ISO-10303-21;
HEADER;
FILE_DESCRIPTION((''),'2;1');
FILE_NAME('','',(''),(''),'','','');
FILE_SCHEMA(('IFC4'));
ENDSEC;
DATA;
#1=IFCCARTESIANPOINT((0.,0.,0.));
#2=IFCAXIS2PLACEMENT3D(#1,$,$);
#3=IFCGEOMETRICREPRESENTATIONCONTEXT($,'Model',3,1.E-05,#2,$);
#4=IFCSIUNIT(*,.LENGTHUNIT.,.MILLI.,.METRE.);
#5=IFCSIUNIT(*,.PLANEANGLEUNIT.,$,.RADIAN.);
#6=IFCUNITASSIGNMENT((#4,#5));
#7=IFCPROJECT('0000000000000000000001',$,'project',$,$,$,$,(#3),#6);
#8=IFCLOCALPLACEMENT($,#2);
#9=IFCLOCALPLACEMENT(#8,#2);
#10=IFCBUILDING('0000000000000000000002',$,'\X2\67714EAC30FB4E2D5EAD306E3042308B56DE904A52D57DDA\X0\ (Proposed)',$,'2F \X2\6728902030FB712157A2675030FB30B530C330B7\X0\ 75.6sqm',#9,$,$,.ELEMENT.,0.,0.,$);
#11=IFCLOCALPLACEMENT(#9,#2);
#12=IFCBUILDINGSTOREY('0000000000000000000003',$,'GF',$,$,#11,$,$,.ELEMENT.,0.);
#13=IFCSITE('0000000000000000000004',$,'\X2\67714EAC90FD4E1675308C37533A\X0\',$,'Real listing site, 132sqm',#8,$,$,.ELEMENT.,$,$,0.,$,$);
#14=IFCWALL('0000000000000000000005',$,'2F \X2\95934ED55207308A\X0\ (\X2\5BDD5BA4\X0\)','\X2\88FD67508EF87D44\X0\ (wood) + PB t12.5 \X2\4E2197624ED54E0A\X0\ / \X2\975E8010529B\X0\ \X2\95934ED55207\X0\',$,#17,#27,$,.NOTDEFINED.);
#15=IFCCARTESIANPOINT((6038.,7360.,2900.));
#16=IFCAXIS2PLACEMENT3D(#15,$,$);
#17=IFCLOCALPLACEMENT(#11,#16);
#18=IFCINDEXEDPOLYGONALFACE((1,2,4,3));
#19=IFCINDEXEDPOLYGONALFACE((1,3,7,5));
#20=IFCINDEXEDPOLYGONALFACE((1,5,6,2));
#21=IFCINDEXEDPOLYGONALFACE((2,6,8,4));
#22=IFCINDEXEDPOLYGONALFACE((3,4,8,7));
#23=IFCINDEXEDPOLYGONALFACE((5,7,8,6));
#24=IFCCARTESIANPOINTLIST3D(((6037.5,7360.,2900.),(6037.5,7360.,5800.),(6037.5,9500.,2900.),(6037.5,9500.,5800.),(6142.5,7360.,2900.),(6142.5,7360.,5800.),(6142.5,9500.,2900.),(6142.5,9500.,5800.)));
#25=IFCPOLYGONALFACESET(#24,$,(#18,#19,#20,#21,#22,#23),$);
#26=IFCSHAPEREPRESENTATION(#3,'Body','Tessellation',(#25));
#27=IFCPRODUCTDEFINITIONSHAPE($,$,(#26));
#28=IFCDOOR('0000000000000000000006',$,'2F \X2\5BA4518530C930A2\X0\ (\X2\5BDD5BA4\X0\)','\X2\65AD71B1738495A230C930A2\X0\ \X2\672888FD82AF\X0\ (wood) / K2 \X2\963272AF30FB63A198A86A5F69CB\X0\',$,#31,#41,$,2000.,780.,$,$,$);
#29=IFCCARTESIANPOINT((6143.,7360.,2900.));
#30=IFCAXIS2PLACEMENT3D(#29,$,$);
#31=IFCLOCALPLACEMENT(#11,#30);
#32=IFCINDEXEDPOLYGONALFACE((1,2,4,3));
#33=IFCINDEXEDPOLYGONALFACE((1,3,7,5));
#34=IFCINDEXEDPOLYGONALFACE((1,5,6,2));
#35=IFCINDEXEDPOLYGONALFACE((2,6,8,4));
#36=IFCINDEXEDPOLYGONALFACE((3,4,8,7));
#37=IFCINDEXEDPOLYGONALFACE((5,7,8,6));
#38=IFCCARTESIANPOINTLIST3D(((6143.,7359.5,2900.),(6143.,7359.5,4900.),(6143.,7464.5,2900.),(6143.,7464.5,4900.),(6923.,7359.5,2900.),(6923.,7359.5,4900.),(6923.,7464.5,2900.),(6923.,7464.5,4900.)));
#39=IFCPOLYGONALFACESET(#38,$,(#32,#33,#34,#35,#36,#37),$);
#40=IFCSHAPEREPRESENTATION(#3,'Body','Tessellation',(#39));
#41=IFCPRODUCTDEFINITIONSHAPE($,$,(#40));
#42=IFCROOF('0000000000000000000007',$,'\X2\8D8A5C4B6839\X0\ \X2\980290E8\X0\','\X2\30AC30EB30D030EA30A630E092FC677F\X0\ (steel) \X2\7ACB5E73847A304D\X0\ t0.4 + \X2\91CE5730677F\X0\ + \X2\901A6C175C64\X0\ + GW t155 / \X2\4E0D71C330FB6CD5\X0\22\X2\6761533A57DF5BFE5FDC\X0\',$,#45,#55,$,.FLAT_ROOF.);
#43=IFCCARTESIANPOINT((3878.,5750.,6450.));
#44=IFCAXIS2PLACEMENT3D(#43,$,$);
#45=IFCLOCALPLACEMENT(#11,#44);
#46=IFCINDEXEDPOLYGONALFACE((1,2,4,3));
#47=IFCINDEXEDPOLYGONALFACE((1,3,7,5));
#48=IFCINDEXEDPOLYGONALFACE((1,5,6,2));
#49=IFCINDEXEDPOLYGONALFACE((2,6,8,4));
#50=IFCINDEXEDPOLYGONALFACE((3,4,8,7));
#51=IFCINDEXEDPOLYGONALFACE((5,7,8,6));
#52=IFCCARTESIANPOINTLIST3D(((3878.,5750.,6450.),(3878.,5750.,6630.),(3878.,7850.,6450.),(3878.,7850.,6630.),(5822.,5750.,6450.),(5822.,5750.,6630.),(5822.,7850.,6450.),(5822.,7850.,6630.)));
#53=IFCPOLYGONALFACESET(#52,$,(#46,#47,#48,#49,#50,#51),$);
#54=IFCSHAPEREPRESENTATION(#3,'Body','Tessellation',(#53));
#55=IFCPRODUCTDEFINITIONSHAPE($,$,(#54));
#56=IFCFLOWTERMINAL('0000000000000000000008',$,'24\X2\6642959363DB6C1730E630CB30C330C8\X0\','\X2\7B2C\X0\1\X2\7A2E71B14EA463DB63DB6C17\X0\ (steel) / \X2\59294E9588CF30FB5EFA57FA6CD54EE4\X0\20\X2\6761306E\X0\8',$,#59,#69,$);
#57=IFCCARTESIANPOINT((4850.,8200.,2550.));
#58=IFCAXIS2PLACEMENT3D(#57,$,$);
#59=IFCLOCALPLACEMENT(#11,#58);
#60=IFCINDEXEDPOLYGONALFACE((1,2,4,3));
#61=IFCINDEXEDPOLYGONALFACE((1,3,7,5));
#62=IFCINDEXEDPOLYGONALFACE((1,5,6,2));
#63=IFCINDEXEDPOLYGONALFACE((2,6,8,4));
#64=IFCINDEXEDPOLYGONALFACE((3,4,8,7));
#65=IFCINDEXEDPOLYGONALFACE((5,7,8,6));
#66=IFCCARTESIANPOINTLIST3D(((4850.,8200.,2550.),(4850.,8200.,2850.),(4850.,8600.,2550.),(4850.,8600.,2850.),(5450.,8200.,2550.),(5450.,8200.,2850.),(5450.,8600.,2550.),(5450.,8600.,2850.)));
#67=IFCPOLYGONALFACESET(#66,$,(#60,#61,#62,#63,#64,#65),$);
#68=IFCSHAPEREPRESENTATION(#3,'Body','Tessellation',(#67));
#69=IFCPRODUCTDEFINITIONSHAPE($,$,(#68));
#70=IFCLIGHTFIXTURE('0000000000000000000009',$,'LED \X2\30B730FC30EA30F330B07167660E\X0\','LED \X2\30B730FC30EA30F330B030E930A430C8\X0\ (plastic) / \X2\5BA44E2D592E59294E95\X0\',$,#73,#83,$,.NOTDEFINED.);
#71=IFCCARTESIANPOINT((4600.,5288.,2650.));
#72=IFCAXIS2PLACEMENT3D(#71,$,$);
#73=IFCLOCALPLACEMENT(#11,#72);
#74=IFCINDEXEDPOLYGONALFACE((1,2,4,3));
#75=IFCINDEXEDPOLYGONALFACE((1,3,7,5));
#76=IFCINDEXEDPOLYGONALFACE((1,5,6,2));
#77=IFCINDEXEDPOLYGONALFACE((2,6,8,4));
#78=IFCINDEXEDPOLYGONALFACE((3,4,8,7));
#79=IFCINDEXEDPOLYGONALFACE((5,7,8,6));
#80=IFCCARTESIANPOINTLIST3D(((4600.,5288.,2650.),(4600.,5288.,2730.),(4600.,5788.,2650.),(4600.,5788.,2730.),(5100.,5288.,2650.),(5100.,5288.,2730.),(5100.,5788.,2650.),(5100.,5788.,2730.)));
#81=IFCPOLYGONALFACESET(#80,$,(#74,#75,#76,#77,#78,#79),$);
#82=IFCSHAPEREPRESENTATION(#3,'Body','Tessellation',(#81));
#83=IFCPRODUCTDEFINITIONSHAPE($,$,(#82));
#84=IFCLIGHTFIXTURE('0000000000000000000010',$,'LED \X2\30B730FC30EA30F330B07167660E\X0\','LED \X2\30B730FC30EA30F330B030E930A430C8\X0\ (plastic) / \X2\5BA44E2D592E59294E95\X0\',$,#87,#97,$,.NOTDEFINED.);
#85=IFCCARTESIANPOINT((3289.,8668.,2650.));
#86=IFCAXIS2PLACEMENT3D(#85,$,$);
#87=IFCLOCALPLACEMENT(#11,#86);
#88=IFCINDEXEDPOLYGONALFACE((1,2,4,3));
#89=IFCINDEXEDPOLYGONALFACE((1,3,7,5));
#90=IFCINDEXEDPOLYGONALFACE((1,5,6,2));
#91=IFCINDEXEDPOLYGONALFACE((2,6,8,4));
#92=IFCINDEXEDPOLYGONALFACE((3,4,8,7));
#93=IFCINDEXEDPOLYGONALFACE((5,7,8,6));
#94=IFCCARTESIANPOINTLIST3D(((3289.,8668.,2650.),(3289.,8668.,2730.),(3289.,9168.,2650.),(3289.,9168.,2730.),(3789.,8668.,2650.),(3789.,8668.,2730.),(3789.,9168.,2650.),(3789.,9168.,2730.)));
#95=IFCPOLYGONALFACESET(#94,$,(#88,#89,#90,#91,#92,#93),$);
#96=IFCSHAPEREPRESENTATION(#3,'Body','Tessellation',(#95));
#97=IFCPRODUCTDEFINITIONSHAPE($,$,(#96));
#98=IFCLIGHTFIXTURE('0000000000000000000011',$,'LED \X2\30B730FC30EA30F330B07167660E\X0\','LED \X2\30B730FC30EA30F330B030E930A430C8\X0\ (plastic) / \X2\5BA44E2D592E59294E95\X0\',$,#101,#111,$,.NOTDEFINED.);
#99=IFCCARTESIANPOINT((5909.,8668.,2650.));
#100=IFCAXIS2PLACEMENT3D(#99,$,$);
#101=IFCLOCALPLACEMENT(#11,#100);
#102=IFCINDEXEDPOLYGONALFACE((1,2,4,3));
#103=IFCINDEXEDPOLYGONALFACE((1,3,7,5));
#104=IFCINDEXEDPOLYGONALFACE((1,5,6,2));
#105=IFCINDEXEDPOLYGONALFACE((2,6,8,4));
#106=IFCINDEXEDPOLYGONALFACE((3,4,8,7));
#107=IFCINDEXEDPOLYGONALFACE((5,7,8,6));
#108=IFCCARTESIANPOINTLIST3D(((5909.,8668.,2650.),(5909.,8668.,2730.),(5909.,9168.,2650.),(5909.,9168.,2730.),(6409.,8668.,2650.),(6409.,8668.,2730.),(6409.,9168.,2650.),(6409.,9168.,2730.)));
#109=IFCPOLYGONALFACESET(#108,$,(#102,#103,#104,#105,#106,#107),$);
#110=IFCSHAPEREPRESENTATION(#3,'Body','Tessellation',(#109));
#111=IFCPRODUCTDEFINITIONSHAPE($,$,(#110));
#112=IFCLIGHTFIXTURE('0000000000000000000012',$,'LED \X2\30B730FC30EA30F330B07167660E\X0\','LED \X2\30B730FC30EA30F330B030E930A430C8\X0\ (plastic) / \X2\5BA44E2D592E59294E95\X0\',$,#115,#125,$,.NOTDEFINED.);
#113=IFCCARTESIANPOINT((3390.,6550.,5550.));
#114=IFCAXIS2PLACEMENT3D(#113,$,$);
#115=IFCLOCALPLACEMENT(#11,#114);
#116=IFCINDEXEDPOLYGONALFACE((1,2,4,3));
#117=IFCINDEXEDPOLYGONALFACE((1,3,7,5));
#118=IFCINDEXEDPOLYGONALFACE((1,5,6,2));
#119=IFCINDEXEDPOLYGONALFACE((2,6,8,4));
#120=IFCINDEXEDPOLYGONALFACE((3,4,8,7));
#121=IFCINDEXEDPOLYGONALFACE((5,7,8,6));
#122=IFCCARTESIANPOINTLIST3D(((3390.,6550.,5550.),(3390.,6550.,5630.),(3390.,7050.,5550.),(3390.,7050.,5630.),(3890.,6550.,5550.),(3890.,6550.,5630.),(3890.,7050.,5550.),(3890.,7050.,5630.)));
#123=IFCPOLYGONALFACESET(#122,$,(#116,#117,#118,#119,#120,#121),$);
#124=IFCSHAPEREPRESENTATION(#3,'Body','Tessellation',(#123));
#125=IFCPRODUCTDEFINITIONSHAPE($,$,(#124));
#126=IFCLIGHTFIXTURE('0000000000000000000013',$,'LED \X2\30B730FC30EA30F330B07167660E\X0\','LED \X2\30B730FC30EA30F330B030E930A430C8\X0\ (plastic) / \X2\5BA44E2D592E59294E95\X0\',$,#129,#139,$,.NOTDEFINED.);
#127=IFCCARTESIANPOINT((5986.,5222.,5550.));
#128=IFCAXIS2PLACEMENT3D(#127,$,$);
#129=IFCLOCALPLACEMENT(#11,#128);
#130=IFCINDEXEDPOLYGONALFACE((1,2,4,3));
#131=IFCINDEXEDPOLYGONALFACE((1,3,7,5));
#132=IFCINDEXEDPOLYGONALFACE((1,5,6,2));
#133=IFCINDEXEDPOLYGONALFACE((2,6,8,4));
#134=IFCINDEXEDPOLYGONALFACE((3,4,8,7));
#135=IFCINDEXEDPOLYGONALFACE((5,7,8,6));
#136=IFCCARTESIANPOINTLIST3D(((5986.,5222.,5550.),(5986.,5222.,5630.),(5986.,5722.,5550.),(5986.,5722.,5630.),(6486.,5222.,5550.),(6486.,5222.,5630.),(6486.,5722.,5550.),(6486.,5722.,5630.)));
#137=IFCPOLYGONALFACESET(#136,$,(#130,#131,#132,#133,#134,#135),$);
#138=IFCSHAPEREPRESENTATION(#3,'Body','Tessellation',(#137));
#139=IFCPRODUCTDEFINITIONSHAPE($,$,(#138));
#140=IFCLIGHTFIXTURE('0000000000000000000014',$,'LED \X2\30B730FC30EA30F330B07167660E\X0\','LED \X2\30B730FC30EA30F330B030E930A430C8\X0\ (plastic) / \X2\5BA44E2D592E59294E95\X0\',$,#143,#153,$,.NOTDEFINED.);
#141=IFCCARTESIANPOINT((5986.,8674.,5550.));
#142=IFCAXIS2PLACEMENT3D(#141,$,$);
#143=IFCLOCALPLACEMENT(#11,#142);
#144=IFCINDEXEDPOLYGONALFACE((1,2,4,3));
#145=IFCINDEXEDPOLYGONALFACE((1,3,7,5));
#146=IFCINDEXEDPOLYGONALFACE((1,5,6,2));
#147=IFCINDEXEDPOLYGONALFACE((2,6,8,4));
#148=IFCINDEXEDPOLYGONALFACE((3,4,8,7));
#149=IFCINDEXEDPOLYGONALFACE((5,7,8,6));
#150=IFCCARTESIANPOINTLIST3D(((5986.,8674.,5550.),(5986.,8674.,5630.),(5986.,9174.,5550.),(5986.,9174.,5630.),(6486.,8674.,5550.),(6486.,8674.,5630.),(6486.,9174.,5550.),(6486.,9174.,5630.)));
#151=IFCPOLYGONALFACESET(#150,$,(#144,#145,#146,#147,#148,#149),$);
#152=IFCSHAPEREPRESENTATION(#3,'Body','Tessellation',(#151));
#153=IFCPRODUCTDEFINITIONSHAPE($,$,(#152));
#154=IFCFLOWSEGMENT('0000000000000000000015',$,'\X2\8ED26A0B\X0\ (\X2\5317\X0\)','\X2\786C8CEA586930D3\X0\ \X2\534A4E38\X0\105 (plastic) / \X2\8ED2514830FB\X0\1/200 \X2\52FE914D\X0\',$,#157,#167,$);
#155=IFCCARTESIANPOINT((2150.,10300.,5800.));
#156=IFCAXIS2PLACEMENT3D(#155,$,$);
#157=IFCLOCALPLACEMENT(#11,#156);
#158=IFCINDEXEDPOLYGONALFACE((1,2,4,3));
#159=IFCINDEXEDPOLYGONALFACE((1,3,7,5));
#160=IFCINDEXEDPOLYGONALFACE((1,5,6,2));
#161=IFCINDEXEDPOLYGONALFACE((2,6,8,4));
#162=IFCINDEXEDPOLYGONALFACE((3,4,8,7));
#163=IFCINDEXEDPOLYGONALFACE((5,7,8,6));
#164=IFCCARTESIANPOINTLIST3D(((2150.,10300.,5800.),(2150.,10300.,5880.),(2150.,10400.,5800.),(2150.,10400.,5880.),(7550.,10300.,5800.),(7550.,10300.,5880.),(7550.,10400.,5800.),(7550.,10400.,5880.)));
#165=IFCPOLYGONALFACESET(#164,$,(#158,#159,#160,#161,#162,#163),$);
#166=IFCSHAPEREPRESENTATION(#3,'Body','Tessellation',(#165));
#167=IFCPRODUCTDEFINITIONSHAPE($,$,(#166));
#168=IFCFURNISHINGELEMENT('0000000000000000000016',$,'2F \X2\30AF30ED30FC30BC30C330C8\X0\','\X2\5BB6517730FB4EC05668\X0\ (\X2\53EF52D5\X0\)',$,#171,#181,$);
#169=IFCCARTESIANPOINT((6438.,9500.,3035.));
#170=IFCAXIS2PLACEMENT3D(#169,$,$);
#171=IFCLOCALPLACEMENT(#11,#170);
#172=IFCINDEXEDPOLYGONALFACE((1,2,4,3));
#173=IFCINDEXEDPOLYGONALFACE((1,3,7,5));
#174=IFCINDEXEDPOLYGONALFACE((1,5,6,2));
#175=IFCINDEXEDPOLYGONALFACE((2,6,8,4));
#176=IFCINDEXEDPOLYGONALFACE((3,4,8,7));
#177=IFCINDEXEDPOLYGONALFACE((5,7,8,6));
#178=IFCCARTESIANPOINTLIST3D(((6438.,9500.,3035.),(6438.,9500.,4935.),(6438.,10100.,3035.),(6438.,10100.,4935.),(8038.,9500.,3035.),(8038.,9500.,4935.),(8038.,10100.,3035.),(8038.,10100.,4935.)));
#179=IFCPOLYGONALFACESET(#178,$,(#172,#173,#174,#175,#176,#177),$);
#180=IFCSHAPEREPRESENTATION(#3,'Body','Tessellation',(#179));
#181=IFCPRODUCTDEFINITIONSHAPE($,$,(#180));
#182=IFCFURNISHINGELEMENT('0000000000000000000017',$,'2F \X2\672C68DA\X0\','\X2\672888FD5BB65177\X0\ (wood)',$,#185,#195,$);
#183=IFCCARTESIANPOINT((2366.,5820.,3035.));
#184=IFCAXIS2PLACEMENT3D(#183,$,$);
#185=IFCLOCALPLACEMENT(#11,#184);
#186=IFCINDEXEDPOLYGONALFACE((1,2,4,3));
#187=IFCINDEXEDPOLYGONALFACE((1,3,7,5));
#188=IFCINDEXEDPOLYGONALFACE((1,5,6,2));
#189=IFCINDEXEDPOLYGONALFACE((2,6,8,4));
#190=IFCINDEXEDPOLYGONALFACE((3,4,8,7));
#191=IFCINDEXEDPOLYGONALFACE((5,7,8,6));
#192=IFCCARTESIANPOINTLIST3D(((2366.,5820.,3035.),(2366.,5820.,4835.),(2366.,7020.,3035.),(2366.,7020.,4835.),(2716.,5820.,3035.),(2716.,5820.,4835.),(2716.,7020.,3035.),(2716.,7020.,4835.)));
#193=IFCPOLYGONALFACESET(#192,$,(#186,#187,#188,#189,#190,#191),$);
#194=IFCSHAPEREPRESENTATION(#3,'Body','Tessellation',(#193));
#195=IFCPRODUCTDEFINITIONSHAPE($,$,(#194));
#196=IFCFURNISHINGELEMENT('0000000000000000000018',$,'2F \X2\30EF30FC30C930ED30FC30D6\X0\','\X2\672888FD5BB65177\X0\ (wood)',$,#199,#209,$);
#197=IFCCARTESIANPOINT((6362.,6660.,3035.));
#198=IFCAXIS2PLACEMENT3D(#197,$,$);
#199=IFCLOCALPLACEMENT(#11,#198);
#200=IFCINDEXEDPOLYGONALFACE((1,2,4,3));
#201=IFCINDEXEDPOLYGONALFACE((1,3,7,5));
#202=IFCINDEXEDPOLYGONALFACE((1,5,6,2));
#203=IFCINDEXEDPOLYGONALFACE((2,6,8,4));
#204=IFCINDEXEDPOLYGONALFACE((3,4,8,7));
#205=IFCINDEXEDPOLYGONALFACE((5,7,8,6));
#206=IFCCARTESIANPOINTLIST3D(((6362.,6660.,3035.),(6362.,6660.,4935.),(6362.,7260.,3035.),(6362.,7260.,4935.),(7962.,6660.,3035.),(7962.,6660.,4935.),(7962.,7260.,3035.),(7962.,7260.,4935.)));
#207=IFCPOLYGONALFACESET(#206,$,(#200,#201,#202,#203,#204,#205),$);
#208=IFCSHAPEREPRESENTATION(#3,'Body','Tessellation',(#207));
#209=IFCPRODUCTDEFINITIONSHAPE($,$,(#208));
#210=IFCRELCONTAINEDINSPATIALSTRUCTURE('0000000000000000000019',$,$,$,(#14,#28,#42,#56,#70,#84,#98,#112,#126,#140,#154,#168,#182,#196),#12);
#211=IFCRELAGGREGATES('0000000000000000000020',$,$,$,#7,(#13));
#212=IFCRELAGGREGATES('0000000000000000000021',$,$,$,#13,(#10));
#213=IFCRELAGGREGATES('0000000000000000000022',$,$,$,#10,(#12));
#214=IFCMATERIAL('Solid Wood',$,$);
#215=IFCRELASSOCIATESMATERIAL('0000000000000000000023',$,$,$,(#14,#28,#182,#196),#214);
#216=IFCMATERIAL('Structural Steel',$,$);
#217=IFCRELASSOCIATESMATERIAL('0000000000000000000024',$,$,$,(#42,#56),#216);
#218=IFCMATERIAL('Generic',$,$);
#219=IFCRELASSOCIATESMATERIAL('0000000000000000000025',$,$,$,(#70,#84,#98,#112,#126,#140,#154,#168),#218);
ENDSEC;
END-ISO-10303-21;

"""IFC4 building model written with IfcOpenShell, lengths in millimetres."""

from ifc_helpers import new_model, si_unit, frame, frame_2d, origin, place, context, project, spatial, rectangle, extrude, material, element, save


model = new_model("IFC4")

# Units and contexts
model_context = context("Model", 3, precision=1e-05, world=origin())
ifc_project = project(units=[si_unit("LENGTHUNIT", "METRE", prefix="MILLI"), si_unit("PLANEANGLEUNIT", "RADIAN")], contexts=[model_context])

# Site, building, storey
site_placement = place(None, origin())
site = spatial("IfcSite", under=ifc_project, at=site_placement, Name="東京都世田谷区", ObjectType="Real listing site, 132sqm", CompositionType="ELEMENT", RefElevation=0.0)
building_placement = place(site_placement, origin())
building = spatial("IfcBuilding", under=site, at=building_placement, Name="東京・中庭のある回遊動線 (Proposed)", ObjectType="2F 木造・無垢材・サッシ 75.6sqm", CompositionType="ELEMENT", ElevationOfRefHeight=0.0, ElevationOfTerrain=0.0)
storey_placement = place(building_placement, origin())
storey = spatial("IfcBuildingStorey", under=building, at=storey_placement, Name="GF", CompositionType="ELEMENT", Elevation=0.0)

# Shared definitions
ifc_material_1 = material(Name="Solid Wood")

# Wall
wall_1_placement = place(storey_placement, frame((6038.0, 7360.0, 2900.0)))
element("IfcWall", 1, at=wall_1_placement, inside=storey, material=ifc_material_1, Name="2F 間仕切り (寝室)", Description="製材軸組 (wood) + PB t12.5 両面仕上 / 非耐力 間仕切", PredefinedType="NOTDEFINED", context=model_context, shape_type="SweptSolid", body=[
    extrude(rectangle(XDim=105.0, YDim=2140.0, at=frame_2d((52.0, 1070.0))), frame((6038.0, 7360.0, 2900.0)), (0.0, 0.0, 1.0), 2900.0),
])

# Door
door_placement = place(storey_placement, frame((6143.0, 7360.0, 2900.0)))
element("IfcDoor", 2, at=door_placement, inside=storey, material=ifc_material_1, Name="2F 室内ドア (寝室)", Description="断熱玄関ドア 木製芯 (wood) / K2 防犯・採風機構", OverallHeight=2000.0, OverallWidth=780.0, context=model_context, shape_type="SweptSolid", body=[
    extrude(rectangle(XDim=780.0, YDim=105.0, at=frame_2d((390.0, 52.0))), frame((6143.0, 7360.0, 2900.0)), (0.0, 0.0, 1.0), 2000.0),
])

# Roof
ifc_material_2 = material(Name="Structural Steel")
roof_placement = place(storey_placement, frame((3878.0, 5750.0, 6450.0)))
element("IfcRoof", 3, at=roof_placement, inside=storey, material=ifc_material_2, Name="越屋根 頂部", Description="ガルバリウム鋼板 (steel) 立平葺き t0.4 + 野地板 + 通気層 + GW t155 / 不燃・法22条区域対応", PredefinedType="FLAT_ROOF", context=model_context, shape_type="SweptSolid", body=[
    extrude(rectangle(XDim=1944.0, YDim=2100.0, at=frame_2d((972.0, 1050.0))), frame((3878.0, 5750.0, 6450.0)), (0.0, 0.0, 1.0), 180.0),
])

# Flow terminal
flow_terminal_placement = place(storey_placement, frame((4850.0, 8200.0, 2550.0)))
element("IfcFlowTerminal", 4, at=flow_terminal_placement, inside=storey, material=ifc_material_2, Name="24時間換気ユニット", Description="第1種熱交換換気 (steel) / 天井裏・建基法令20条の8", context=model_context, shape_type="SweptSolid", body=[
    extrude(rectangle(XDim=600.0, YDim=400.0, at=frame_2d((300.0, 200.0))), frame((4850.0, 8200.0, 2550.0)), (0.0, 0.0, 1.0), 300.0),
])

# Light fixtures
ifc_material_3 = material(Name="Generic")
light_fixture_1_placement = place(storey_placement, frame((4600.0, 5288.0, 2650.0)))
element("IfcLightFixture", 5, at=light_fixture_1_placement, inside=storey, material=ifc_material_3, Name="LED シーリング照明", Description="LED シーリングライト (plastic) / 室中央天井", PredefinedType="NOTDEFINED", context=model_context, shape_type="SweptSolid", body=[
    extrude(rectangle(XDim=500.0, YDim=500.0, at=frame_2d((250.0, 250.0))), frame((4600.0, 5288.0, 2650.0)), (0.0, 0.0, 1.0), 80.0),
])
light_fixture_2_placement = place(storey_placement, frame((3289.0, 8668.0, 2650.0)))
element("IfcLightFixture", 6, at=light_fixture_2_placement, inside=storey, material=ifc_material_3, Name="LED シーリング照明", Description="LED シーリングライト (plastic) / 室中央天井", PredefinedType="NOTDEFINED", context=model_context, shape_type="SweptSolid", body=[
    extrude(rectangle(XDim=500.0, YDim=500.0, at=frame_2d((250.0, 250.0))), frame((3289.0, 8668.0, 2650.0)), (0.0, 0.0, 1.0), 80.0),
])
light_fixture_3_placement = place(storey_placement, frame((5909.0, 8668.0, 2650.0)))
element("IfcLightFixture", 7, at=light_fixture_3_placement, inside=storey, material=ifc_material_3, Name="LED シーリング照明", Description="LED シーリングライト (plastic) / 室中央天井", PredefinedType="NOTDEFINED", context=model_context, shape_type="SweptSolid", body=[
    extrude(rectangle(XDim=500.0, YDim=500.0, at=frame_2d((250.0, 250.0))), frame((5909.0, 8668.0, 2650.0)), (0.0, 0.0, 1.0), 80.0),
])
light_fixture_4_placement = place(storey_placement, frame((3390.0, 6550.0, 5550.0)))
element("IfcLightFixture", 8, at=light_fixture_4_placement, inside=storey, material=ifc_material_3, Name="LED シーリング照明", Description="LED シーリングライト (plastic) / 室中央天井", PredefinedType="NOTDEFINED", context=model_context, shape_type="SweptSolid", body=[
    extrude(rectangle(XDim=500.0, YDim=500.0, at=frame_2d((250.0, 250.0))), frame((3390.0, 6550.0, 5550.0)), (0.0, 0.0, 1.0), 80.0),
])
light_fixture_5_placement = place(storey_placement, frame((5986.0, 5222.0, 5550.0)))
element("IfcLightFixture", 9, at=light_fixture_5_placement, inside=storey, material=ifc_material_3, Name="LED シーリング照明", Description="LED シーリングライト (plastic) / 室中央天井", PredefinedType="NOTDEFINED", context=model_context, shape_type="SweptSolid", body=[
    extrude(rectangle(XDim=500.0, YDim=500.0, at=frame_2d((250.0, 250.0))), frame((5986.0, 5222.0, 5550.0)), (0.0, 0.0, 1.0), 80.0),
])
light_fixture_6_placement = place(storey_placement, frame((5986.0, 8674.0, 5550.0)))
element("IfcLightFixture", 10, at=light_fixture_6_placement, inside=storey, material=ifc_material_3, Name="LED シーリング照明", Description="LED シーリングライト (plastic) / 室中央天井", PredefinedType="NOTDEFINED", context=model_context, shape_type="SweptSolid", body=[
    extrude(rectangle(XDim=500.0, YDim=500.0, at=frame_2d((250.0, 250.0))), frame((5986.0, 8674.0, 5550.0)), (0.0, 0.0, 1.0), 80.0),
])

# Flow segment
flow_segment_placement = place(storey_placement, frame((2150.0, 10300.0, 5800.0)))
element("IfcFlowSegment", 11, at=flow_segment_placement, inside=storey, material=ifc_material_3, Name="軒樋 (北)", Description="硬質塩ビ 半丸105 (plastic) / 軒先・1/200 勾配", context=model_context, shape_type="SweptSolid", body=[
    extrude(rectangle(XDim=5400.0, YDim=100.0, at=frame_2d((2700.0, 50.0))), frame((2150.0, 10300.0, 5800.0)), (0.0, 0.0, 1.0), 80.0),
])

# Furnishing elements
furnishing_1_placement = place(storey_placement, frame((6438.0, 9500.0, 3035.0)))
element("IfcFurnishingElement", 12, at=furnishing_1_placement, inside=storey, material=ifc_material_3, Name="2F クローゼット", Description="家具・什器 (可動)", context=model_context, shape_type="SweptSolid", body=[
    extrude(rectangle(XDim=1600.0, YDim=600.0, at=frame_2d((800.0, 300.0))), frame((6438.0, 9500.0, 3035.0)), (0.0, 0.0, 1.0), 1900.0),
])
furnishing_2_placement = place(storey_placement, frame((2366.0, 5820.0, 3035.0)))
element("IfcFurnishingElement", 13, at=furnishing_2_placement, inside=storey, material=ifc_material_1, Name="2F 本棚", Description="木製家具 (wood)", context=model_context, shape_type="SweptSolid", body=[
    extrude(rectangle(XDim=350.0, YDim=1200.0, at=frame_2d((175.0, 600.0))), frame((2366.0, 5820.0, 3035.0)), (0.0, 0.0, 1.0), 1800.0),
])
furnishing_3_placement = place(storey_placement, frame((6362.0, 6660.0, 3035.0)))
element("IfcFurnishingElement", 14, at=furnishing_3_placement, inside=storey, material=ifc_material_1, Name="2F ワードローブ", Description="木製家具 (wood)", context=model_context, shape_type="SweptSolid", body=[
    extrude(rectangle(XDim=1600.0, YDim=600.0, at=frame_2d((800.0, 300.0))), frame((6362.0, 6660.0, 3035.0)), (0.0, 0.0, 1.0), 1900.0),
])

save(model, "model.ifc")
